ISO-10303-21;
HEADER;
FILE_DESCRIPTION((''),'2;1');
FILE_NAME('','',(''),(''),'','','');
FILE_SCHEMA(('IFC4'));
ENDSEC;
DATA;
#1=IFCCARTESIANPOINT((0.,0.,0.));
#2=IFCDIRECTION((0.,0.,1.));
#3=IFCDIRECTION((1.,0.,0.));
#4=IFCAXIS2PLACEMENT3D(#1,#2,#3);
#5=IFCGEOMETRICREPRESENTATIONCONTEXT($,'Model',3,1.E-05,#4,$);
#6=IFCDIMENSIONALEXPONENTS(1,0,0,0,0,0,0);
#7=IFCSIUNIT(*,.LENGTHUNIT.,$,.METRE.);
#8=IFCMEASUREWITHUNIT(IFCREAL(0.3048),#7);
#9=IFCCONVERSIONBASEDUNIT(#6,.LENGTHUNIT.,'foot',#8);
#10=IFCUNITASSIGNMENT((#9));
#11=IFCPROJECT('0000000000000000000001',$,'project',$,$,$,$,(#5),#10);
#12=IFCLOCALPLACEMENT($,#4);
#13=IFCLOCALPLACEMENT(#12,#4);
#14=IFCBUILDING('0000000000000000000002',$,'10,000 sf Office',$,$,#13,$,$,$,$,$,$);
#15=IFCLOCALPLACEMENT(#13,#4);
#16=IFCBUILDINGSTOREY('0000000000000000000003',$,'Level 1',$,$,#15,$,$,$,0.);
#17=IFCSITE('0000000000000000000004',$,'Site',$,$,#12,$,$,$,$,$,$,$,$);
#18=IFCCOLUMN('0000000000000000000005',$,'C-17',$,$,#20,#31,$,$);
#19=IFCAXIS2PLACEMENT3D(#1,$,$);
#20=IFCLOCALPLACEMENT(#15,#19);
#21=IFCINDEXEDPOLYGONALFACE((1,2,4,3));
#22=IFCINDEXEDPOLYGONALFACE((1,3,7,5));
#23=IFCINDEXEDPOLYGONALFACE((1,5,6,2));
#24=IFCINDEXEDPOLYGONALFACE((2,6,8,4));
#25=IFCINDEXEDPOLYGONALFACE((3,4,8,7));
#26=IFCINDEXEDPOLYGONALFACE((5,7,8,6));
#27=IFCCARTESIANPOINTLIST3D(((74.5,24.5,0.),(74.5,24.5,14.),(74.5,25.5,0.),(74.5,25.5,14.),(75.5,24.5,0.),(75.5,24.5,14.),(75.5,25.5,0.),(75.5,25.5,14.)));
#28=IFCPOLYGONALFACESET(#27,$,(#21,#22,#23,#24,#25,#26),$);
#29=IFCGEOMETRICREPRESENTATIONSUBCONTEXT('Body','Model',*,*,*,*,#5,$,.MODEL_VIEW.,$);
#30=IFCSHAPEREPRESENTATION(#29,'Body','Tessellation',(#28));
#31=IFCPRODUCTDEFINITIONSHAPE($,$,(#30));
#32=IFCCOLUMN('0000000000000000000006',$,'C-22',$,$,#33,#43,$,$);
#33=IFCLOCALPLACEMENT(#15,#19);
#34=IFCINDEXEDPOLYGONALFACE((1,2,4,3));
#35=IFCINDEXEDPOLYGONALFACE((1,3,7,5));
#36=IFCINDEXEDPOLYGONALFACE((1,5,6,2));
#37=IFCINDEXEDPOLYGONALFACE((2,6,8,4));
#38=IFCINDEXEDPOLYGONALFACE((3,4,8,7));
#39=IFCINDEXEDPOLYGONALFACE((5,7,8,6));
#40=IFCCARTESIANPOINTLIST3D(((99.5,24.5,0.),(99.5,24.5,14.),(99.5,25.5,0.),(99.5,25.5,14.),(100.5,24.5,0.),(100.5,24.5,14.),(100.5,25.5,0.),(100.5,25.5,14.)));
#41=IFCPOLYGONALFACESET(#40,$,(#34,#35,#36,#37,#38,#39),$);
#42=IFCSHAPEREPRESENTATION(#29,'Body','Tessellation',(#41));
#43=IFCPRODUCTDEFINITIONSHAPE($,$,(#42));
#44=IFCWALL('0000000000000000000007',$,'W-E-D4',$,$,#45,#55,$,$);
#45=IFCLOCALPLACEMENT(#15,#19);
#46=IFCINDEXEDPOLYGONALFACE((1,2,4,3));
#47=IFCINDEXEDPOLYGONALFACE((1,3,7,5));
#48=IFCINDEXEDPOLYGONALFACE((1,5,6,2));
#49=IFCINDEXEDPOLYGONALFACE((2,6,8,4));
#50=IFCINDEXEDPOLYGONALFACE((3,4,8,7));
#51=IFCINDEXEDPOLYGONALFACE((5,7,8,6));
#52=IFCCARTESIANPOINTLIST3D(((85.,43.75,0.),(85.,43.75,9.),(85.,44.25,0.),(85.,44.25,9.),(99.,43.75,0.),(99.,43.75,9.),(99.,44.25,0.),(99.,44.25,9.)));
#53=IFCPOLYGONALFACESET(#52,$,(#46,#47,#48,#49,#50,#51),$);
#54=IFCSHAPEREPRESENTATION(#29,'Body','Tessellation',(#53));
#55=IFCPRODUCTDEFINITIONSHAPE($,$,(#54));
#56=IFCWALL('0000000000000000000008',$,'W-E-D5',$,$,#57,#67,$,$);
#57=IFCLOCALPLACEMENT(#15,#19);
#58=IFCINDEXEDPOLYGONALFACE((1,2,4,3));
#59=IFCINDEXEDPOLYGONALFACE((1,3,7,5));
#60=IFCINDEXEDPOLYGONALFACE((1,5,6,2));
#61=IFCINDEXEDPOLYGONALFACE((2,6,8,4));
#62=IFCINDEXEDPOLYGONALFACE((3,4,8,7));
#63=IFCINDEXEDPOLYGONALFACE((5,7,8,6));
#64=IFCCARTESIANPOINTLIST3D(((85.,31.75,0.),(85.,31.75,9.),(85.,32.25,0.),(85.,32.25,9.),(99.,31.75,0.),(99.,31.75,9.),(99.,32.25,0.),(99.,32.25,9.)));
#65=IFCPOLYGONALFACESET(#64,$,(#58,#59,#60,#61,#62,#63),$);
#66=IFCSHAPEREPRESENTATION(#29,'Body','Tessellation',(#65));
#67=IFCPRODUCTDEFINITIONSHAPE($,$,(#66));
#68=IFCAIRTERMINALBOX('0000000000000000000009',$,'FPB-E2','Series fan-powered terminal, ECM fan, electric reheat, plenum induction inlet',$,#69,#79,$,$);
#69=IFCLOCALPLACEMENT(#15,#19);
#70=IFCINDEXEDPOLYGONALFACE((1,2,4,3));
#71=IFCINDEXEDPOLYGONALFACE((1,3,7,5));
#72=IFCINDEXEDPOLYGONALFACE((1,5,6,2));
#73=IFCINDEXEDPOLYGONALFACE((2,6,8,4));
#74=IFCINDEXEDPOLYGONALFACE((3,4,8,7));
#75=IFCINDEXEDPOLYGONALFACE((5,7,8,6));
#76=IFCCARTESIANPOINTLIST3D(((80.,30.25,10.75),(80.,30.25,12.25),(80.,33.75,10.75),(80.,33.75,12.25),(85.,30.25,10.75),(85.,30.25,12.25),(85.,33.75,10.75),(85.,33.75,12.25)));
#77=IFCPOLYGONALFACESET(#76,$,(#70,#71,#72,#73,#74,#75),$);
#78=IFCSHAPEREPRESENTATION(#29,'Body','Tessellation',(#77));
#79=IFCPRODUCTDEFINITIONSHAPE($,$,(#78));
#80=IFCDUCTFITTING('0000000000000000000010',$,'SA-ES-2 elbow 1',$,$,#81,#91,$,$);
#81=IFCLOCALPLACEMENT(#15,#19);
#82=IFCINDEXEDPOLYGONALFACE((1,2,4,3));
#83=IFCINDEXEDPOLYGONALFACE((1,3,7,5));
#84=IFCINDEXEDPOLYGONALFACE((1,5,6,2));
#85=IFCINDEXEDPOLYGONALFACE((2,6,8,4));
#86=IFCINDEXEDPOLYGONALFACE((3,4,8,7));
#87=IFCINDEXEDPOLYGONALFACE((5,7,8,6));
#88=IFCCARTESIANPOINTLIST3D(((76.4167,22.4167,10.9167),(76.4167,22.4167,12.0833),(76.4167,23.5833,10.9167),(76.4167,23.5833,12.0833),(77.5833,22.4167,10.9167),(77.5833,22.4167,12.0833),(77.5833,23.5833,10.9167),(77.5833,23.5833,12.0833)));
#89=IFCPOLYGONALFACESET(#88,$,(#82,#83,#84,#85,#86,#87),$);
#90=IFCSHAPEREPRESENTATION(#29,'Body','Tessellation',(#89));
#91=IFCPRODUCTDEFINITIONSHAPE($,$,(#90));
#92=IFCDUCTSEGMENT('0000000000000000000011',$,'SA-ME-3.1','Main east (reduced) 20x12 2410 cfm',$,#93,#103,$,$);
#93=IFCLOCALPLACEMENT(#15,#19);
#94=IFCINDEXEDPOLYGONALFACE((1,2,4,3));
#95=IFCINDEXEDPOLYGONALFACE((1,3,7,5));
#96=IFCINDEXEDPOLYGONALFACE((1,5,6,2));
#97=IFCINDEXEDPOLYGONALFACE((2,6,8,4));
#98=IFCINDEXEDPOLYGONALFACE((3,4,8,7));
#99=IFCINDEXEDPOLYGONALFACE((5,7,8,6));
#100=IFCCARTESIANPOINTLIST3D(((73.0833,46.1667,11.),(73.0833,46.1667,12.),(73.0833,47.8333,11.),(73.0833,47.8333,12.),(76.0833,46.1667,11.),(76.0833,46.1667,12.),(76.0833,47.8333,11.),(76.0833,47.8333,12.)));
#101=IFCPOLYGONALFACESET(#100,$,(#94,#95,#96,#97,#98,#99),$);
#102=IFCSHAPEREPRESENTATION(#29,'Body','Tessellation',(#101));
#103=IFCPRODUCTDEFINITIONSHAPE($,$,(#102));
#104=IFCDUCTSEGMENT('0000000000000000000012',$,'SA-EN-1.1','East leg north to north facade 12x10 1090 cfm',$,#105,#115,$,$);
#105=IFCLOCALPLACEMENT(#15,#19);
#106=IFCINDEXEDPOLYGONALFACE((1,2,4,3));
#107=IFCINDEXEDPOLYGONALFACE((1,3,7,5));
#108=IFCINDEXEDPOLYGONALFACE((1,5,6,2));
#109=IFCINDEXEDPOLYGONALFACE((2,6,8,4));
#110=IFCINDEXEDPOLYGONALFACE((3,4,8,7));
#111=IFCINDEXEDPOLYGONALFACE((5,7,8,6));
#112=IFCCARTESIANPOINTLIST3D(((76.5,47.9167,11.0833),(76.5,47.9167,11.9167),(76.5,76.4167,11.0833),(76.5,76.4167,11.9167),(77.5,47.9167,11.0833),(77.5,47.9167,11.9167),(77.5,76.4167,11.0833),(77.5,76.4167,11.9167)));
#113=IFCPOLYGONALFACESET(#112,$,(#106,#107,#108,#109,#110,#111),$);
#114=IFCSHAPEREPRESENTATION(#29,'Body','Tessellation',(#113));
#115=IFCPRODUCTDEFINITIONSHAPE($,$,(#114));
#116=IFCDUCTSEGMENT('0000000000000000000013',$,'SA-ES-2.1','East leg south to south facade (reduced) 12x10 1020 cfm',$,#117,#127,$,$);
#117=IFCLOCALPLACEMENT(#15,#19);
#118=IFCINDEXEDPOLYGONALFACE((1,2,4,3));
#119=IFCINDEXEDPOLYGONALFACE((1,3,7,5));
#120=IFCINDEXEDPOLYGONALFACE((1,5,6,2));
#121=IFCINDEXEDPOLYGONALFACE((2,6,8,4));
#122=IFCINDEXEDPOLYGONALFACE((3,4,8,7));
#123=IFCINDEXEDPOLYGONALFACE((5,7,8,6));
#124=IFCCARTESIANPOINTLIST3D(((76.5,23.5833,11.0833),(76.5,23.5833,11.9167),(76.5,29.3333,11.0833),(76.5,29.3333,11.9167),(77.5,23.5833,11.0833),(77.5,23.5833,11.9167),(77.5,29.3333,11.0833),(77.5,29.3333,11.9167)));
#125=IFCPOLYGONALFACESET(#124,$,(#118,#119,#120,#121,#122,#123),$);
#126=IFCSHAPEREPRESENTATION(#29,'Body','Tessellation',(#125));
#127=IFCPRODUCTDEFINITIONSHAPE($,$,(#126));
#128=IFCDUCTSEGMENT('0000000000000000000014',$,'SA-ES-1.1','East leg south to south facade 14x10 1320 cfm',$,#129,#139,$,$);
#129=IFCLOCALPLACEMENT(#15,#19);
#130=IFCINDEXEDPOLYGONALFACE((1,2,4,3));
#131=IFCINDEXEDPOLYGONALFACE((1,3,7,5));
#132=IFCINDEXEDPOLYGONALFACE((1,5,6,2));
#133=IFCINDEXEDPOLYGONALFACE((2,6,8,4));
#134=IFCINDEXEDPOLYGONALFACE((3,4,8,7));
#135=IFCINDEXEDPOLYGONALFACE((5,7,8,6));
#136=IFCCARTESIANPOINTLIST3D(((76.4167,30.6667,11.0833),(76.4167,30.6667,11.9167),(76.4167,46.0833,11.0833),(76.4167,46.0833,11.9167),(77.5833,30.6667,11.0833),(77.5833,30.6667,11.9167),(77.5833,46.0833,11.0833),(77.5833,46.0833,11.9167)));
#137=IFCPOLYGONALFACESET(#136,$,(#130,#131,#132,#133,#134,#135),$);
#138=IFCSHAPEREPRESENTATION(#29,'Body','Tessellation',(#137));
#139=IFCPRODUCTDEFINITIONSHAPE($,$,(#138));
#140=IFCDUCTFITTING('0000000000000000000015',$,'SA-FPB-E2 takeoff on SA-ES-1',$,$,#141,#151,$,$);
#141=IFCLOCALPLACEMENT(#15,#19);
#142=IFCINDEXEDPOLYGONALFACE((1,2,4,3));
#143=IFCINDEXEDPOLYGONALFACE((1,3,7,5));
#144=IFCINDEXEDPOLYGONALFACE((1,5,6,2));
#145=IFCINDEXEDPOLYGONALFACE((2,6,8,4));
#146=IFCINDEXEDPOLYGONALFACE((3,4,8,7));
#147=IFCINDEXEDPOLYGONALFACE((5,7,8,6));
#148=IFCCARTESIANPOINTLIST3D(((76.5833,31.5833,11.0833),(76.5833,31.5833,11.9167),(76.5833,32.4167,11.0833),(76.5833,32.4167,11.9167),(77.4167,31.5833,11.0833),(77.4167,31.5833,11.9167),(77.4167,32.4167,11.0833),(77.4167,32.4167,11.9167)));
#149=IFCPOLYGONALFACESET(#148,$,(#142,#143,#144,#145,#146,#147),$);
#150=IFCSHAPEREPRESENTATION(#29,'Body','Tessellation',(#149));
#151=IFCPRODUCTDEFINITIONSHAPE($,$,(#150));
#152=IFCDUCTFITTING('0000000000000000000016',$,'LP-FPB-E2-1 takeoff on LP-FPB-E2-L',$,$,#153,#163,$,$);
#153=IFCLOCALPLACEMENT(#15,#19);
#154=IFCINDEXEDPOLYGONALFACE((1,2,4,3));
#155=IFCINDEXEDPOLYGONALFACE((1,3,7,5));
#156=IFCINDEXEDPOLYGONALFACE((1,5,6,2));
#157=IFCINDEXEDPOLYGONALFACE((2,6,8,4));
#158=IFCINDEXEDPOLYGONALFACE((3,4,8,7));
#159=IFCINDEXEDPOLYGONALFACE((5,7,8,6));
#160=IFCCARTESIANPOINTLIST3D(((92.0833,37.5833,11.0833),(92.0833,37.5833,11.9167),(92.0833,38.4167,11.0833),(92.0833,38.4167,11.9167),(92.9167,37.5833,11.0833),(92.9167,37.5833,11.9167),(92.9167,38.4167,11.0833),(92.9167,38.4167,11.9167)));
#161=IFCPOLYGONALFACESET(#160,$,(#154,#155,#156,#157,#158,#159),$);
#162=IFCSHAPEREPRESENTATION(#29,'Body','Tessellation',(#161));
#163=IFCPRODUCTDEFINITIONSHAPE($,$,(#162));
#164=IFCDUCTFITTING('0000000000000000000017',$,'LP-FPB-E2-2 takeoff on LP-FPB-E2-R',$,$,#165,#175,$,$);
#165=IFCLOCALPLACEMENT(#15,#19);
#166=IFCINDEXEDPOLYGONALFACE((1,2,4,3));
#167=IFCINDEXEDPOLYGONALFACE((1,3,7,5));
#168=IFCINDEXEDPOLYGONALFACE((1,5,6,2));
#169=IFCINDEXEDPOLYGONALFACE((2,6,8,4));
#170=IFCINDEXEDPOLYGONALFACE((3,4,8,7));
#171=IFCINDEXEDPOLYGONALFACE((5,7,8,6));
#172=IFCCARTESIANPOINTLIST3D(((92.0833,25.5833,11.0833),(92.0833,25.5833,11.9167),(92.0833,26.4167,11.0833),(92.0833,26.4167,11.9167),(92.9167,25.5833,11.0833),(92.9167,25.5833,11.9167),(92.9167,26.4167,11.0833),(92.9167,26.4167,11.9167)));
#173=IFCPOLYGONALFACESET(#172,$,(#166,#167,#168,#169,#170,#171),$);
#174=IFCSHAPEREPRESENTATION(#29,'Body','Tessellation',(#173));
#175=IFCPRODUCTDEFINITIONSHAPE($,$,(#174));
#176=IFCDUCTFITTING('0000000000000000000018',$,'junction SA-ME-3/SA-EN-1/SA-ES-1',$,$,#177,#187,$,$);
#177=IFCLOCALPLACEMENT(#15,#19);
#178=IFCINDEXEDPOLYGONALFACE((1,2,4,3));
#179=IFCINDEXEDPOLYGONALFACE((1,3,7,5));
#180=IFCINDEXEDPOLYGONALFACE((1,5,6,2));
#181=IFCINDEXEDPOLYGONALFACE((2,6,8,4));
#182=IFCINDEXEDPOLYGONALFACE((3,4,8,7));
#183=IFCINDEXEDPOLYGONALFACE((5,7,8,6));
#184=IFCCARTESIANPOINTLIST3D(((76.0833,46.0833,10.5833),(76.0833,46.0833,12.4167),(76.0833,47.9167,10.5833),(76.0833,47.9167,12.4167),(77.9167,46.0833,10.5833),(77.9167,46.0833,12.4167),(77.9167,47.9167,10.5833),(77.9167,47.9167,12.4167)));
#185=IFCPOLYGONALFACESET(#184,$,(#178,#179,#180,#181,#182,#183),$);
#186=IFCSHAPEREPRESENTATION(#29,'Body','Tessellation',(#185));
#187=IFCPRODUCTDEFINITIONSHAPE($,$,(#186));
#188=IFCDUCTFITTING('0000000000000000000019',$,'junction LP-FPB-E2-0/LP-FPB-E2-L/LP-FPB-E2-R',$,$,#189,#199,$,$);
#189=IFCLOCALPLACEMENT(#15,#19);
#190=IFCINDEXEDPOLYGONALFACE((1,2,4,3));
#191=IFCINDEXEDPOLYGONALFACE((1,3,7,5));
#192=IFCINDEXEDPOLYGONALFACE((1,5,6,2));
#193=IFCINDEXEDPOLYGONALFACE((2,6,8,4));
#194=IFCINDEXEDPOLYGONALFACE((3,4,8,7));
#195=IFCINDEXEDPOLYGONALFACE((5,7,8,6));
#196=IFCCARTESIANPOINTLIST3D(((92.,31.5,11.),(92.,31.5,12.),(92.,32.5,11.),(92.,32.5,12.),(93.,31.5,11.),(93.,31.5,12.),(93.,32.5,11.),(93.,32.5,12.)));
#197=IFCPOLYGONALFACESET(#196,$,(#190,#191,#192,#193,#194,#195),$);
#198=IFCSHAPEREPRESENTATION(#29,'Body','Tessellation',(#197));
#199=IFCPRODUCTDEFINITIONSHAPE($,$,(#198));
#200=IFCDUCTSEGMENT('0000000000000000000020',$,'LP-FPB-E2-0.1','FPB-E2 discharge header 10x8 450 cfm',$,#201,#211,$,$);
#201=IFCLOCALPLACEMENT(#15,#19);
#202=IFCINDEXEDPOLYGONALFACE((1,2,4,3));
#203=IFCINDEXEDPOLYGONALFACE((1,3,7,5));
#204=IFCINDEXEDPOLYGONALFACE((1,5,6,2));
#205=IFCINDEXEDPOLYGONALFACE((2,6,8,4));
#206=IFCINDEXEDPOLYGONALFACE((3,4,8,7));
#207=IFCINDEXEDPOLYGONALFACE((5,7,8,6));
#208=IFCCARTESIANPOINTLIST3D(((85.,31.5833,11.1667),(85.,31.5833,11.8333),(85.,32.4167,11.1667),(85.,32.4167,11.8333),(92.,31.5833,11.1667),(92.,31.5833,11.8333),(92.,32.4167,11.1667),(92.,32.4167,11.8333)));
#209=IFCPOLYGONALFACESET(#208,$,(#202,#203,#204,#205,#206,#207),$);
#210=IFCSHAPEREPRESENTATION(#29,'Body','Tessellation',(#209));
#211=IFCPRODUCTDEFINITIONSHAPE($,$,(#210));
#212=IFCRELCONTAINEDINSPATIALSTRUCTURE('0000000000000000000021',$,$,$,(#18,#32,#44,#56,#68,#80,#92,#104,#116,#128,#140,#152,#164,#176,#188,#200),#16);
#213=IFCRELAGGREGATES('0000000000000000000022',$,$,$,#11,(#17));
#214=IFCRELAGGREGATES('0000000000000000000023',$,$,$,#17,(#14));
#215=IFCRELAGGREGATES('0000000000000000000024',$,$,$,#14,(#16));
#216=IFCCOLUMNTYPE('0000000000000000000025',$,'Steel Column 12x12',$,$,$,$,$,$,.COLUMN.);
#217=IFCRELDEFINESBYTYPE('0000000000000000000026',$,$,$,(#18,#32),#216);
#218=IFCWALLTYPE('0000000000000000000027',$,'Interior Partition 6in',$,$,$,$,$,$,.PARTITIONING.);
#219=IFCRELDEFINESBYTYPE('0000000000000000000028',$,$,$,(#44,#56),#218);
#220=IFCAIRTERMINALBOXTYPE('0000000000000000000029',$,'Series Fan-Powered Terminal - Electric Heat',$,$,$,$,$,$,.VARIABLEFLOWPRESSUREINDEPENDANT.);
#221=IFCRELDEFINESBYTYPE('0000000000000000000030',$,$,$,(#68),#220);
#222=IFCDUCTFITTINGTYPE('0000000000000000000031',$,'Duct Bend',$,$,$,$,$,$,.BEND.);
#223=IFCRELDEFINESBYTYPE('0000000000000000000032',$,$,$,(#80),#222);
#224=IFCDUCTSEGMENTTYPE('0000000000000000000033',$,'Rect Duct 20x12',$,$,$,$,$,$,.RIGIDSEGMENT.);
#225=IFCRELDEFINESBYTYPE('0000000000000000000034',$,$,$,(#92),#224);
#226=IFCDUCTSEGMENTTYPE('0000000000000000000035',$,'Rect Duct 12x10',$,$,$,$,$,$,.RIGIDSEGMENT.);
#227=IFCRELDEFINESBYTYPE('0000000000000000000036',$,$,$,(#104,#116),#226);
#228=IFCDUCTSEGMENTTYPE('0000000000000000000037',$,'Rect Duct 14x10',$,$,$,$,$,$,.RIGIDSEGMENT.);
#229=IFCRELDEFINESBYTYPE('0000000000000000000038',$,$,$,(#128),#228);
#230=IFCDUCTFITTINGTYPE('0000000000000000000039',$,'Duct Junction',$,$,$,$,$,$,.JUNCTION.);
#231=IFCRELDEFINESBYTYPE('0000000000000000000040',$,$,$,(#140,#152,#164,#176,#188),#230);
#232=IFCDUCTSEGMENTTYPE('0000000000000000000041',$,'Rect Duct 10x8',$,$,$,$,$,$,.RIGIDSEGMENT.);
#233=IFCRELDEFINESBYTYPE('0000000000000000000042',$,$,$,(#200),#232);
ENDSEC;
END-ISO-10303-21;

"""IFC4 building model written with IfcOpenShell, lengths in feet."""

from ifc_helpers import new_model, entity, si_unit, converted_unit, frame, origin_with_axes, place, context, subcontext, project, spatial, rectangle, extrude, type_object, element, save


model = new_model("IFC4")

# Units and contexts
model_context = context("Model", 3, precision=1e-05, world=origin_with_axes())
body_context = subcontext(model_context, "Body", "Model", "MODEL_VIEW")
ifc_project = project(units=[converted_unit("LENGTHUNIT", "foot", entity("IfcReal", 0.3048), si_unit("LENGTHUNIT", "METRE"), dimensions=[1, 0, 0, 0, 0, 0, 0])], contexts=[model_context])

# Site, building, storey
site_placement = place(None, origin_with_axes())
site = spatial("IfcSite", under=ifc_project, at=site_placement, Name="Site")
building_placement = place(site_placement, origin_with_axes())
building = spatial("IfcBuilding", under=site, at=building_placement, Name="10,000 sf Office")
storey_placement = place(building_placement, origin_with_axes())
storey = spatial("IfcBuildingStorey", under=building, at=storey_placement, Name="Level 1", Elevation=0.0)

# Columns
column_type = type_object("IfcColumnType", Name="Steel Column 12x12", PredefinedType="COLUMN")
for number, where, z_axis, x_axis, name in (
    (1, (75.0, 25.0, 0.0), (0.0, 0.0, 1.0), (1.0, 0.0, 0.0), "C-17"),
    (2, (100.0, 25.0, 0.0), (0.0, 0.0, 1.0), (1.0, 0.0, 0.0), "C-22"),
):
    element("IfcColumn", number, at=place(storey_placement, frame(where, z_axis=z_axis, x_axis=x_axis)), inside=storey, type_object=column_type, Name=name, context=body_context, shape_type="SweptSolid", body=[
        extrude(rectangle(XDim=1.0, YDim=1.0), None, (0.0, 0.0, 1.0), 14.0),
    ])

# Walls
wall_type = type_object("IfcWallType", Name="Interior Partition 6in", PredefinedType="PARTITIONING")
for number, where, z_axis, x_axis, name in (
    (3, (92.0, 44.0, 0.0), (0.0, 0.0, 1.0), (-1.0, 0.0, 0.0), "W-E-D4"),
    (4, (92.0, 32.0, 0.0), (0.0, 0.0, 1.0), (-1.0, 0.0, 0.0), "W-E-D5"),
):
    element("IfcWall", number, at=place(storey_placement, frame(where, z_axis=z_axis, x_axis=x_axis)), inside=storey, type_object=wall_type, Name=name, context=body_context, shape_type="SweptSolid", body=[
        extrude(rectangle(XDim=14.0, YDim=0.5), None, (0.0, 0.0, 1.0), 9.0),
    ])

# Air terminal box
air_terminal_box_type = type_object("IfcAirTerminalBoxType", Name="Series Fan-Powered Terminal - Electric Heat", PredefinedType="VARIABLEFLOWPRESSUREINDEPENDANT")
air_terminal_box_placement = place(storey_placement, frame((82.5, 32.0, 10.75), z_axis=(0.0, 0.0, 1.0), x_axis=(1.0, 0.0, 0.0)))
element("IfcAirTerminalBox", 5, at=air_terminal_box_placement, inside=storey, type_object=air_terminal_box_type, Name="FPB-E2", Description="Series fan-powered terminal, ECM fan, electric reheat, plenum induction inlet", context=body_context, shape_type="SweptSolid", body=[
    extrude(rectangle(XDim=5.0, YDim=3.5), None, (0.0, 0.0, 1.0), 1.5),
])

# Duct fitting
duct_fitting_type_1 = type_object("IfcDuctFittingType", Name="Duct Bend", PredefinedType="BEND")
duct_fitting_1_placement = place(storey_placement, frame((77.0, 23.0, 10.9167), z_axis=(0.0, 0.0, 1.0), x_axis=(1.0, 0.0, 0.0)))
element("IfcDuctFitting", 6, at=duct_fitting_1_placement, inside=storey, type_object=duct_fitting_type_1, Name="SA-ES-2 elbow 1", context=body_context, shape_type="SweptSolid", body=[
    extrude(rectangle(XDim=1.1667, YDim=1.1667), None, (0.0, 0.0, 1.0), 1.1667),
])

# Duct segments
duct_segment_type_1 = type_object("IfcDuctSegmentType", Name="Rect Duct 20x12", PredefinedType="RIGIDSEGMENT")
duct_segment_1_placement = place(storey_placement, frame((73.0833, 47.0, 11.5), z_axis=(1.0, 0.0, 0.0), x_axis=(0.0, 1.0, 0.0)))
element("IfcDuctSegment", 7, at=duct_segment_1_placement, inside=storey, type_object=duct_segment_type_1, Name="SA-ME-3.1", Description="Main east (reduced) 20x12 2410 cfm", context=body_context, shape_type="SweptSolid", body=[
    extrude(rectangle(XDim=1.6667, YDim=1.0), None, (0.0, 0.0, 1.0), 3.0),
])
duct_segment_type_2 = type_object("IfcDuctSegmentType", Name="Rect Duct 12x10", PredefinedType="RIGIDSEGMENT")
duct_segment_2_placement = place(storey_placement, frame((77.0, 47.9167, 11.5), z_axis=(0.0, 1.0, 0.0), x_axis=(-1.0, 0.0, 0.0)))
element("IfcDuctSegment", 8, at=duct_segment_2_placement, inside=storey, type_object=duct_segment_type_2, Name="SA-EN-1.1", Description="East leg north to north facade 12x10 1090 cfm", context=body_context, shape_type="SweptSolid", body=[
    extrude(rectangle(XDim=1.0, YDim=0.8333), None, (0.0, 0.0, 1.0), 28.5),
])
duct_segment_3_placement = place(storey_placement, frame((77.0, 29.3333, 11.5), z_axis=(0.0, -1.0, 0.0), x_axis=(1.0, 0.0, 0.0)))
element("IfcDuctSegment", 9, at=duct_segment_3_placement, inside=storey, type_object=duct_segment_type_2, Name="SA-ES-2.1", Description="East leg south to south facade (reduced) 12x10 1020 cfm", context=body_context, shape_type="SweptSolid", body=[
    extrude(rectangle(XDim=1.0, YDim=0.8333), None, (0.0, 0.0, 1.0), 5.75),
])
duct_segment_type_3 = type_object("IfcDuctSegmentType", Name="Rect Duct 14x10", PredefinedType="RIGIDSEGMENT")
duct_segment_4_placement = place(storey_placement, frame((77.0, 46.0833, 11.5), z_axis=(0.0, -1.0, 0.0), x_axis=(1.0, 0.0, 0.0)))
element("IfcDuctSegment", 10, at=duct_segment_4_placement, inside=storey, type_object=duct_segment_type_3, Name="SA-ES-1.1", Description="East leg south to south facade 14x10 1320 cfm", context=body_context, shape_type="SweptSolid", body=[
    extrude(rectangle(XDim=1.1667, YDim=0.8333), None, (0.0, 0.0, 1.0), 15.4167),
])

# Duct fittings
duct_fitting_type_2 = type_object("IfcDuctFittingType", Name="Duct Junction", PredefinedType="JUNCTION")
for number, where, z_axis, x_axis, name in (
    (11, (77.0, 32.0, 11.0833), (0.0, 0.0, 1.0), (1.0, 0.0, 0.0), "SA-FPB-E2 takeoff on SA-ES-1"),
    (12, (92.5, 38.0, 11.0833), (0.0, 0.0, 1.0), (1.0, 0.0, 0.0), "LP-FPB-E2-1 takeoff on LP-FPB-E2-L"),
    (13, (92.5, 26.0, 11.0833), (0.0, 0.0, 1.0), (1.0, 0.0, 0.0), "LP-FPB-E2-2 takeoff on LP-FPB-E2-R"),
):
    element("IfcDuctFitting", number, at=place(storey_placement, frame(where, z_axis=z_axis, x_axis=x_axis)), inside=storey, type_object=duct_fitting_type_2, Name=name, context=body_context, shape_type="SweptSolid", body=[
        extrude(rectangle(XDim=0.8333, YDim=0.8333), None, (0.0, 0.0, 1.0), 0.8333),
    ])
duct_fitting_2_placement = place(storey_placement, frame((77.0, 47.0, 10.5833), z_axis=(0.0, 0.0, 1.0), x_axis=(1.0, 0.0, 0.0)))
element("IfcDuctFitting", 14, at=duct_fitting_2_placement, inside=storey, type_object=duct_fitting_type_2, Name="junction SA-ME-3/SA-EN-1/SA-ES-1", context=body_context, shape_type="SweptSolid", body=[
    extrude(rectangle(XDim=1.8333, YDim=1.8333), None, (0.0, 0.0, 1.0), 1.8333),
])
duct_fitting_3_placement = place(storey_placement, frame((92.5, 32.0, 11.0), z_axis=(0.0, 0.0, 1.0), x_axis=(1.0, 0.0, 0.0)))
element("IfcDuctFitting", 15, at=duct_fitting_3_placement, inside=storey, type_object=duct_fitting_type_2, Name="junction LP-FPB-E2-0/LP-FPB-E2-L/LP-FPB-E2-R", context=body_context, shape_type="SweptSolid", body=[
    extrude(rectangle(XDim=1.0, YDim=1.0), None, (0.0, 0.0, 1.0), 1.0),
])

# Duct segment
duct_segment_type_4 = type_object("IfcDuctSegmentType", Name="Rect Duct 10x8", PredefinedType="RIGIDSEGMENT")
duct_segment_5_placement = place(storey_placement, frame((85.0, 32.0, 11.5), z_axis=(1.0, 0.0, 0.0), x_axis=(0.0, 1.0, 0.0)))
element("IfcDuctSegment", 16, at=duct_segment_5_placement, inside=storey, type_object=duct_segment_type_4, Name="LP-FPB-E2-0.1", Description="FPB-E2 discharge header 10x8 450 cfm", context=body_context, shape_type="SweptSolid", body=[
    extrude(rectangle(XDim=0.8333, YDim=0.6667), None, (0.0, 0.0, 1.0), 7.0),
])

save(model, "model.ifc")
